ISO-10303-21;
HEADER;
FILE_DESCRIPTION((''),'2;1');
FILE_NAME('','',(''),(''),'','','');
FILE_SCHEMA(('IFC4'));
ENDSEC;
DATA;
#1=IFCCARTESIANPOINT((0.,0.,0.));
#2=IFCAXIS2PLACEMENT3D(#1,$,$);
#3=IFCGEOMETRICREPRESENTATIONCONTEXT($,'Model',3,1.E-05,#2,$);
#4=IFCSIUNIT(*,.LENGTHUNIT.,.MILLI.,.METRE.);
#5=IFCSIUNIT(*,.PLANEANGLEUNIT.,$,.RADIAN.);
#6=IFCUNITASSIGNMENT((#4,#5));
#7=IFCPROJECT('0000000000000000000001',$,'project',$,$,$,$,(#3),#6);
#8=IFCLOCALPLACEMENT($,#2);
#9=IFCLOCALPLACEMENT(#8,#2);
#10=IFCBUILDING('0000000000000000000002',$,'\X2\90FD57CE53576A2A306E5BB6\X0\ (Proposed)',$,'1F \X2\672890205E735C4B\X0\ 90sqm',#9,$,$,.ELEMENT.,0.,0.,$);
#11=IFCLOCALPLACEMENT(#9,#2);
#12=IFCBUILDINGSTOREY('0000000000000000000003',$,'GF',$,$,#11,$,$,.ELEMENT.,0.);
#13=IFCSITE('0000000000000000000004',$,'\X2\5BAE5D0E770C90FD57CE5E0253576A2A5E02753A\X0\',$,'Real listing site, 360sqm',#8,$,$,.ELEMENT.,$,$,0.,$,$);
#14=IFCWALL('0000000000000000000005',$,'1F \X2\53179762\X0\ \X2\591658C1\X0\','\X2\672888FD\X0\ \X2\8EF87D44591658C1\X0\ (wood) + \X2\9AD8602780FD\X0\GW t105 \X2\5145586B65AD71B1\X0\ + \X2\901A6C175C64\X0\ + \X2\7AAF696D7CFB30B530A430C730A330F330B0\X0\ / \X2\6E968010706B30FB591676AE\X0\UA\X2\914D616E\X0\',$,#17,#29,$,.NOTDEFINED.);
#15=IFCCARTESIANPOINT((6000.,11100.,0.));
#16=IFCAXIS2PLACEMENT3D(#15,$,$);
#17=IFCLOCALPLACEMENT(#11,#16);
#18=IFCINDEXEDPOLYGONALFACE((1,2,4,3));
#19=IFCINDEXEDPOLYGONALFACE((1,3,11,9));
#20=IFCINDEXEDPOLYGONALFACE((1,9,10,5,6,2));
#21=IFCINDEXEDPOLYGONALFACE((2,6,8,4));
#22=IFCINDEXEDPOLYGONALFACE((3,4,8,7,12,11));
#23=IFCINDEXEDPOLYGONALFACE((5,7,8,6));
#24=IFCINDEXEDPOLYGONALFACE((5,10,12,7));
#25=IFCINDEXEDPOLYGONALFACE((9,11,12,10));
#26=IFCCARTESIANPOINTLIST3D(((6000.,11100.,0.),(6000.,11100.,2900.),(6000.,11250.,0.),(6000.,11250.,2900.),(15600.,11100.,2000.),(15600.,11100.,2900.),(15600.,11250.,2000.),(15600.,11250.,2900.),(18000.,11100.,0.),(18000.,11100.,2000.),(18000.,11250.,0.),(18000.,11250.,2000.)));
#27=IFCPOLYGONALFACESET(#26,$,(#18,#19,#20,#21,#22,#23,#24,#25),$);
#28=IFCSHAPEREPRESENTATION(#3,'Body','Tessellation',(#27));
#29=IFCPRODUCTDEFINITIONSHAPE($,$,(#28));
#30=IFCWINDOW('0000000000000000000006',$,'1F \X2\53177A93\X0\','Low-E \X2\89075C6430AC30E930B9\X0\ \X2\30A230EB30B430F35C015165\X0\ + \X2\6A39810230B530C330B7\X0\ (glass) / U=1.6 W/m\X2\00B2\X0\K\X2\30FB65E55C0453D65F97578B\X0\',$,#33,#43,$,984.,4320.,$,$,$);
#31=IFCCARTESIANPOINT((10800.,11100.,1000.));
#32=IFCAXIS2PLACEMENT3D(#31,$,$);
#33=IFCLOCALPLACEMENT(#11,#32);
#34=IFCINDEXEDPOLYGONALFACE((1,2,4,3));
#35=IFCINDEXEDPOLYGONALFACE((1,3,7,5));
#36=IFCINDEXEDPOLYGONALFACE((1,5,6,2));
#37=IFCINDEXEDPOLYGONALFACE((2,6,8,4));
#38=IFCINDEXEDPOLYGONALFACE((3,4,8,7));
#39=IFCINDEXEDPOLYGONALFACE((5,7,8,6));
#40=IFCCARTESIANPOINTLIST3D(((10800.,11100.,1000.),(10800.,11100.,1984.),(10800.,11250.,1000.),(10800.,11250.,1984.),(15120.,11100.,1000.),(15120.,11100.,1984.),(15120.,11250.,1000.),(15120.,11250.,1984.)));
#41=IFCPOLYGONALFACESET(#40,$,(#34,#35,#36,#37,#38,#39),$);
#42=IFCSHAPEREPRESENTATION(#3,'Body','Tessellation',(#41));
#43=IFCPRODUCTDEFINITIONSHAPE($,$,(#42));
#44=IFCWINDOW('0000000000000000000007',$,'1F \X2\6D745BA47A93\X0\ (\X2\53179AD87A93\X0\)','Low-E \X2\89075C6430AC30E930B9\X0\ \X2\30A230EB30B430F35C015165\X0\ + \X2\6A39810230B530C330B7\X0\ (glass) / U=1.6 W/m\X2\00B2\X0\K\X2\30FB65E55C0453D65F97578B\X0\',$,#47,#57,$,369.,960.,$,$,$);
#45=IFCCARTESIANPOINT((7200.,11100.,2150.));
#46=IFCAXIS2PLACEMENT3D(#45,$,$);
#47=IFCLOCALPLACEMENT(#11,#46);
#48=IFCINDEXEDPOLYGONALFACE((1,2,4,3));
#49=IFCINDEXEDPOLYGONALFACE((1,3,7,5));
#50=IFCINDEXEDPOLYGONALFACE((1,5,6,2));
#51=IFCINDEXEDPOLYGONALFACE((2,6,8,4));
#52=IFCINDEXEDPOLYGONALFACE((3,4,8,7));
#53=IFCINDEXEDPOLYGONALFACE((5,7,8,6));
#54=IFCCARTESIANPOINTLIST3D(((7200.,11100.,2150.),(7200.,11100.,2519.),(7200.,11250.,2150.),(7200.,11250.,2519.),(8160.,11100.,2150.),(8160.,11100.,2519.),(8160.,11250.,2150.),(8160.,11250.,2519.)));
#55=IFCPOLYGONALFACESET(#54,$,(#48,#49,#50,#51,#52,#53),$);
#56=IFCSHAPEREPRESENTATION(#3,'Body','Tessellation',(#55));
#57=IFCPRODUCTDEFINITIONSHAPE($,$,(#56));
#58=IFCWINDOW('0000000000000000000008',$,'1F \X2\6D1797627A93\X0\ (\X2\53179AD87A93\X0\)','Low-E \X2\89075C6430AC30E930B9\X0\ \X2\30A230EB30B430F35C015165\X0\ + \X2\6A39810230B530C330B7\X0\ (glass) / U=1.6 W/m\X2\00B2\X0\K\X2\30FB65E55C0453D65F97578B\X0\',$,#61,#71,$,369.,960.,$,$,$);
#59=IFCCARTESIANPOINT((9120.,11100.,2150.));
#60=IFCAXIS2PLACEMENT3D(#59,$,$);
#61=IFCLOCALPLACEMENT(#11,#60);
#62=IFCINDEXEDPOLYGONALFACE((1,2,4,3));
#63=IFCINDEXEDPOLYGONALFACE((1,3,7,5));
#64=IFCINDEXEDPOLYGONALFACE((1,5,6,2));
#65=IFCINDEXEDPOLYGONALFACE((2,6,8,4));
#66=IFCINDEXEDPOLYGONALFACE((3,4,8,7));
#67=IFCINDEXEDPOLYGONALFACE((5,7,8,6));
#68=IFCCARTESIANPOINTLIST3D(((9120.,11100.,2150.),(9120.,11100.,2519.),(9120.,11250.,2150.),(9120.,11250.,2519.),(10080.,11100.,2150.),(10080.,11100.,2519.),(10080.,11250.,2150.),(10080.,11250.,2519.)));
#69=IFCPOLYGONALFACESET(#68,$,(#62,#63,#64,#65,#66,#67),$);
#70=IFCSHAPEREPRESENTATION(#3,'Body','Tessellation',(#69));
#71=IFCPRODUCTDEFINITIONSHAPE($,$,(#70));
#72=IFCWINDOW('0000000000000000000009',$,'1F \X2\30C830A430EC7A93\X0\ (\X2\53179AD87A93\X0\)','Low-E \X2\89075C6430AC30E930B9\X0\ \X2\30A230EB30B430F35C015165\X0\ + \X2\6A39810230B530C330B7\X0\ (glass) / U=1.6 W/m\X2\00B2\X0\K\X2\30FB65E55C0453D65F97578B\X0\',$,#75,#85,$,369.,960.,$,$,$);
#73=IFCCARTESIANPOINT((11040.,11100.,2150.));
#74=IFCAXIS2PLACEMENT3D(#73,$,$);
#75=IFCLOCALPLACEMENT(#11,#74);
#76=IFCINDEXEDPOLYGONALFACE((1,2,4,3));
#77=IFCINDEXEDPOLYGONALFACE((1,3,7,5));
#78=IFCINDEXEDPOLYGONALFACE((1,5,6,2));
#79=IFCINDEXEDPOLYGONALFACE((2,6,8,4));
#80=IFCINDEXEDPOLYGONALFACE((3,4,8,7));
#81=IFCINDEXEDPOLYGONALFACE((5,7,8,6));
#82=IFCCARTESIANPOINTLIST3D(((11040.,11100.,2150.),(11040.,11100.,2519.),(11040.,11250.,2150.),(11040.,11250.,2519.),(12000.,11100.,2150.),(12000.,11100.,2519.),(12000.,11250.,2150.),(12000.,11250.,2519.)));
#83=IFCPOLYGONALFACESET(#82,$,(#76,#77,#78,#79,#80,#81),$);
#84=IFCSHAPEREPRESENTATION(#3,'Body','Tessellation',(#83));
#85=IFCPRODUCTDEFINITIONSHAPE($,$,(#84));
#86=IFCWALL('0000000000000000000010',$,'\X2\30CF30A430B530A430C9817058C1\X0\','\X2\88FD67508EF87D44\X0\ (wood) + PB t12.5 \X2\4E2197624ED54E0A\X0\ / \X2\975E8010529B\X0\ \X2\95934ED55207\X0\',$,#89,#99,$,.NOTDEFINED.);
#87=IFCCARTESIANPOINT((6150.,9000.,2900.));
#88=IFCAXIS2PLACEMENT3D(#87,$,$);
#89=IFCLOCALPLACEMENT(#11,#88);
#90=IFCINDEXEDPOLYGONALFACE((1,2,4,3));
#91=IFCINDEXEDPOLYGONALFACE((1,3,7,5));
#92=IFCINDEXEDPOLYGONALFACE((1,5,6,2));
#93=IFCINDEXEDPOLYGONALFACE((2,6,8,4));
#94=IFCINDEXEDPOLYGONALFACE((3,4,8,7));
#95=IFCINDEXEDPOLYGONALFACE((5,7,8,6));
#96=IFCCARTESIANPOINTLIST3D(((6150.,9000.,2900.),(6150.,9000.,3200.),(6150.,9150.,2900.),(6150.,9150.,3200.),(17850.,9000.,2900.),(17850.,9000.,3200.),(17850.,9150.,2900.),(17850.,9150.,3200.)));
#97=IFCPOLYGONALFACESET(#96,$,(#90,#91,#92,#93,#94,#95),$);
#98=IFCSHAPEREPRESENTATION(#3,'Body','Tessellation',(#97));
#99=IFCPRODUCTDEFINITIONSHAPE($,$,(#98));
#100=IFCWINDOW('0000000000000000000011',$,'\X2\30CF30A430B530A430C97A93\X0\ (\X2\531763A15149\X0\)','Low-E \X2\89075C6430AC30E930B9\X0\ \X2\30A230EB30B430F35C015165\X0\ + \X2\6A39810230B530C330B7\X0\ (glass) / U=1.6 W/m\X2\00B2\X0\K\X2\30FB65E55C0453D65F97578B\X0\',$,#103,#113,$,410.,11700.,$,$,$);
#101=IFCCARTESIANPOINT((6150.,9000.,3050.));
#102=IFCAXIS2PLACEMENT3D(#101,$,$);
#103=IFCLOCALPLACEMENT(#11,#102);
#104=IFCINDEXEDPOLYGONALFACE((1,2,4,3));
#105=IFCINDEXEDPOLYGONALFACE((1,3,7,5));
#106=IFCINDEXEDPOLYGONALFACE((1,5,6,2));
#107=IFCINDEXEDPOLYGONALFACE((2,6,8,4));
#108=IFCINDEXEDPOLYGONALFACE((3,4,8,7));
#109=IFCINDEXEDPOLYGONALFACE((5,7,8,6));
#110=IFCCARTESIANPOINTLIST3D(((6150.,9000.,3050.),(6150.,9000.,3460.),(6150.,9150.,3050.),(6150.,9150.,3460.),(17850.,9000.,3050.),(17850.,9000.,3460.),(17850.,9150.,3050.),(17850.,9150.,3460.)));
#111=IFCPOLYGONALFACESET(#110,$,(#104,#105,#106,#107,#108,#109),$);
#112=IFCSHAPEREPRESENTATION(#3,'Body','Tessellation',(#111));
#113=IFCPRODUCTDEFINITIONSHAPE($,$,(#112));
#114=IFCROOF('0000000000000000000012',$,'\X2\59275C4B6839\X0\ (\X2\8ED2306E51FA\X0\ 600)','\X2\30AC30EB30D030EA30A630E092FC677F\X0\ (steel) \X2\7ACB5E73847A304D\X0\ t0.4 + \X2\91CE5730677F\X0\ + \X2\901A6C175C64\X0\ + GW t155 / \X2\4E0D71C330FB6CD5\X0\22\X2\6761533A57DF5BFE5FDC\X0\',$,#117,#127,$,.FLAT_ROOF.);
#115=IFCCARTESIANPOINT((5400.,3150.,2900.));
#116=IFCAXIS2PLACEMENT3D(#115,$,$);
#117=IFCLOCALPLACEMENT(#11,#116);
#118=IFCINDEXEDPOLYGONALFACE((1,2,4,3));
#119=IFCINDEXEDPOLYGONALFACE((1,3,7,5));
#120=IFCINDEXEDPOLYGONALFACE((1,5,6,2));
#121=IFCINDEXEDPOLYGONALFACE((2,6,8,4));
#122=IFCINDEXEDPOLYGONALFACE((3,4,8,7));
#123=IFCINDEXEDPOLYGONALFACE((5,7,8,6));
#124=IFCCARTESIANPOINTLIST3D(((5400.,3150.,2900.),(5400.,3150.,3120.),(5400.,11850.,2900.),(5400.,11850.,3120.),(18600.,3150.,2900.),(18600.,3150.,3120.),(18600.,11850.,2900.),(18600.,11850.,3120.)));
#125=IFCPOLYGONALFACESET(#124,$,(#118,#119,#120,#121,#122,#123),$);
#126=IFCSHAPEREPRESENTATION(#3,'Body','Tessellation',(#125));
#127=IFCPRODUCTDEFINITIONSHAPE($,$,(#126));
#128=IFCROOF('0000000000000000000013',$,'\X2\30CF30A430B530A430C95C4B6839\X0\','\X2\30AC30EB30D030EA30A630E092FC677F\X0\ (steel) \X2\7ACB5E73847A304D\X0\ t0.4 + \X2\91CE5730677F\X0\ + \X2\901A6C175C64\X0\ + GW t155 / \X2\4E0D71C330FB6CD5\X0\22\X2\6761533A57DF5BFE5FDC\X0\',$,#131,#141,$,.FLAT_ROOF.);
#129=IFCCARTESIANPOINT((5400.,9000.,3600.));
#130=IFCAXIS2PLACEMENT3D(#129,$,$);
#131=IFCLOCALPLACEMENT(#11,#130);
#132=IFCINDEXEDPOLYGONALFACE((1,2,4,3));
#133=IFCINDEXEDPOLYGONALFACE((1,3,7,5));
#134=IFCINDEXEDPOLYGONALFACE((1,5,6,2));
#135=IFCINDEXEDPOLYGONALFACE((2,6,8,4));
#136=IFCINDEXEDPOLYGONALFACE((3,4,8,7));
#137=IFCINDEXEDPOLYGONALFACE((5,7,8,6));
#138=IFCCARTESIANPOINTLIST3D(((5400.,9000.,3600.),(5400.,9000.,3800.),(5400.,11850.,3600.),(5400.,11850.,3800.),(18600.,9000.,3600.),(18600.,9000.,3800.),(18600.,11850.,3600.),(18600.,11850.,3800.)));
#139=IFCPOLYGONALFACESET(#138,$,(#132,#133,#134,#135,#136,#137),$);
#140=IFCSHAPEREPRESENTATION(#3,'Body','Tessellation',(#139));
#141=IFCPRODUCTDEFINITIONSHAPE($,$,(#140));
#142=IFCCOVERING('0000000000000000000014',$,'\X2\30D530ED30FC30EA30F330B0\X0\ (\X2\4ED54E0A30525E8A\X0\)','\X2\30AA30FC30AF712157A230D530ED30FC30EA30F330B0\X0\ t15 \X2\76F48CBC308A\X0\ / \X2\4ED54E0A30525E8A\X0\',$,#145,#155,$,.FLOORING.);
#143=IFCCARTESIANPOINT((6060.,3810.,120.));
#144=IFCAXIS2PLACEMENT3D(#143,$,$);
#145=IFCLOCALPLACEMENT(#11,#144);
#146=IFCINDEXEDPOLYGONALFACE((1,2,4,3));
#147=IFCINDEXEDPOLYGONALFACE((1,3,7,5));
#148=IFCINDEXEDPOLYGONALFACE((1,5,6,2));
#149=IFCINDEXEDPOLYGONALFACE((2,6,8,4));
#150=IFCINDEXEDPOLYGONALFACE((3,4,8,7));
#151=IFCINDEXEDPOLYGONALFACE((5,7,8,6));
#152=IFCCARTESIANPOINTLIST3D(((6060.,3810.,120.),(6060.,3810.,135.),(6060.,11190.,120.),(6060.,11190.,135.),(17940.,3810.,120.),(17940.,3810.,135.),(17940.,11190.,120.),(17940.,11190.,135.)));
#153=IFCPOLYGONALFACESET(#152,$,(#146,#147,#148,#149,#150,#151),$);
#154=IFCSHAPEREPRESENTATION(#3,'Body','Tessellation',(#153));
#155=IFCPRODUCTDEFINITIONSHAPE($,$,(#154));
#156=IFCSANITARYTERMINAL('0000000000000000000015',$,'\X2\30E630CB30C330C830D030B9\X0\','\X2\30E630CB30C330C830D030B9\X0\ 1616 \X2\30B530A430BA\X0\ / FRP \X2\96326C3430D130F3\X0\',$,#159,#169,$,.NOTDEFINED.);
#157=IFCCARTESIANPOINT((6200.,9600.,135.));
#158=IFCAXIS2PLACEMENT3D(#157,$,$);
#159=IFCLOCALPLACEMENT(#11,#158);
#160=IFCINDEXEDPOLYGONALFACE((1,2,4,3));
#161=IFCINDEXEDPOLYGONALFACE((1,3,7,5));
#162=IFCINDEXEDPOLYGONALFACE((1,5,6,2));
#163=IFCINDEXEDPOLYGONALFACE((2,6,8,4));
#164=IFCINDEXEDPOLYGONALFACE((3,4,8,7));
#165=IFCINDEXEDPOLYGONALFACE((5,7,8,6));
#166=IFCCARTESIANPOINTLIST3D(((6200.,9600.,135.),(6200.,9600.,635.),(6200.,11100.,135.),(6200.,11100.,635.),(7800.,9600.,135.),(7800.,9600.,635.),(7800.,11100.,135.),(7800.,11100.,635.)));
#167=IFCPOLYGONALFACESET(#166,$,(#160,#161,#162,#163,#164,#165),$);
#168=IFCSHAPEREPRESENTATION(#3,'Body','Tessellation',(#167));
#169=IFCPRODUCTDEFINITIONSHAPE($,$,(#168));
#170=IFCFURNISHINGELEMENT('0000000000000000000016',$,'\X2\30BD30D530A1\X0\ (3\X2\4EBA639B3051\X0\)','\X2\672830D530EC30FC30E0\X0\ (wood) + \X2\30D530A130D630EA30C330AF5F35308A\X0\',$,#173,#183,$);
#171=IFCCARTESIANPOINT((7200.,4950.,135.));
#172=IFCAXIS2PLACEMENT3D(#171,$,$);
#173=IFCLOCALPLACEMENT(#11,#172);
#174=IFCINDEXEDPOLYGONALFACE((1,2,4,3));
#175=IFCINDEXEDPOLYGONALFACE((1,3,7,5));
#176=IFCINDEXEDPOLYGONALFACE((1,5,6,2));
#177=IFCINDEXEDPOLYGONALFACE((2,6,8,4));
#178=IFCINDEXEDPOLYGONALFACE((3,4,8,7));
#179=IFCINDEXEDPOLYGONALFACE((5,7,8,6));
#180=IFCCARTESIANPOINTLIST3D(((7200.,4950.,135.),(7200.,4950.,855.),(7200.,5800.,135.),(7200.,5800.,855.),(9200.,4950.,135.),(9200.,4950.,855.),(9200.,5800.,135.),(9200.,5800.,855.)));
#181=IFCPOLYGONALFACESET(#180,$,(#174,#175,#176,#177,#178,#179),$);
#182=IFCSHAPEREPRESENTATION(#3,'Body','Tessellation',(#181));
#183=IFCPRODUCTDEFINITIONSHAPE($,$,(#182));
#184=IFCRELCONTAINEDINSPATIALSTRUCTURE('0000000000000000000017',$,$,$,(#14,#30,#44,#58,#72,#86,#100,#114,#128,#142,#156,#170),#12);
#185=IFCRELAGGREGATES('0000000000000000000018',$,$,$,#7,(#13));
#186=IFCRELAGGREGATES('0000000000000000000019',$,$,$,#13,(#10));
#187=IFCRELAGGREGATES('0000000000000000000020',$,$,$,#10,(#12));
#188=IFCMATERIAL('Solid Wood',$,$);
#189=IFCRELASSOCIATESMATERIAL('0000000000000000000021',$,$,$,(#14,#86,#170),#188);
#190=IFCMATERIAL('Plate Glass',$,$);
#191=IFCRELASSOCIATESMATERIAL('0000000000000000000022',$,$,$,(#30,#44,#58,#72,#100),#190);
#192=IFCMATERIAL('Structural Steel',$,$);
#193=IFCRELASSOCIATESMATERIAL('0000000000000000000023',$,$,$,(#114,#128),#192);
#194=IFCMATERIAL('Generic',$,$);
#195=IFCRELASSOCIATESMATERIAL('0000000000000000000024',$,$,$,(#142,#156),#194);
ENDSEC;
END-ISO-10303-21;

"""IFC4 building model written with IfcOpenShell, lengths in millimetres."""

from ifc_helpers import new_model, si_unit, frame, frame_2d, origin, place, context, project, spatial, rectangle, extrude, material, element, fill, save


model = new_model("IFC4")

# Units and contexts
model_context = context("Model", 3, precision=1e-05, world=origin())
ifc_project = project(units=[si_unit("LENGTHUNIT", "METRE", prefix="MILLI"), si_unit("PLANEANGLEUNIT", "RADIAN")], contexts=[model_context])

# Site, building, storey
site_placement = place(None, origin())
site = spatial("IfcSite", under=ifc_project, at=site_placement, Name="宮崎県都城市南横市町", ObjectType="Real listing site, 360sqm", CompositionType="ELEMENT", RefElevation=0.0)
building_placement = place(site_placement, origin())
building = spatial("IfcBuilding", under=site, at=building_placement, Name="都城南横の家 (Proposed)", ObjectType="1F 木造平屋 90sqm", CompositionType="ELEMENT", ElevationOfRefHeight=0.0, ElevationOfTerrain=0.0)
storey_placement = place(building_placement, origin())
storey = spatial("IfcBuildingStorey", under=building, at=storey_placement, Name="GF", CompositionType="ELEMENT", Elevation=0.0)

# Shared definitions
ifc_material_1 = material(Name="Solid Wood")

# Shared definitions
ifc_material_2 = material(Name="Plate Glass")

# Wall, openings, windows
wall_1_placement = place(storey_placement, frame((6000.0, 11100.0, 0.0)))
wall_1 = element("IfcWall", 1, at=wall_1_placement, inside=storey, material=ifc_material_1, Name="1F 北面 外壁", Description="木製 軸組外壁 (wood) + 高性能GW t105 充填断熱 + 通気層 + 窯業系サイディング / 準耐火・外皮UA配慮", PredefinedType="NOTDEFINED", context=model_context, shape_type="SweptSolid", body=[
    extrude(rectangle(XDim=12000.0, YDim=150.0, at=frame_2d((6000.0, 75.0))), frame((6000.0, 11100.0, 0.0)), (0.0, 0.0, 1.0), 2900.0),
])
opening_1_placement = place(storey_placement, frame((10800.0, 11100.0, 1000.0)))
opening_1 = element("IfcOpeningElement", 2, at=opening_1_placement, cuts=wall_1, PredefinedType="NOTDEFINED", context=model_context, shape_type="SweptSolid", body=[
    extrude(rectangle(XDim=4320.0, YDim=150.0, at=frame_2d((2160.0, 75.0))), frame((10800.0, 11100.0, 1000.0)), (0.0, 0.0, 1.0), 984.0),
])
opening_2_placement = place(storey_placement, frame((7200.0, 11100.0, 2150.0)))
opening_2 = element("IfcOpeningElement", 3, at=opening_2_placement, cuts=wall_1, PredefinedType="NOTDEFINED", context=model_context, shape_type="SweptSolid", body=[
    extrude(rectangle(XDim=960.0, YDim=150.0, at=frame_2d((480.0, 75.0))), frame((7200.0, 11100.0, 2150.0)), (0.0, 0.0, 1.0), 369.0),
])
opening_3_placement = place(storey_placement, frame((9120.0, 11100.0, 2150.0)))
opening_3 = element("IfcOpeningElement", 4, at=opening_3_placement, cuts=wall_1, PredefinedType="NOTDEFINED", context=model_context, shape_type="SweptSolid", body=[
    extrude(rectangle(XDim=960.0, YDim=150.0, at=frame_2d((480.0, 75.0))), frame((9120.0, 11100.0, 2150.0)), (0.0, 0.0, 1.0), 369.0),
])
opening_4_placement = place(storey_placement, frame((11040.0, 11100.0, 2150.0)))
opening_4 = element("IfcOpeningElement", 5, at=opening_4_placement, cuts=wall_1, PredefinedType="NOTDEFINED", context=model_context, shape_type="SweptSolid", body=[
    extrude(rectangle(XDim=960.0, YDim=150.0, at=frame_2d((480.0, 75.0))), frame((11040.0, 11100.0, 2150.0)), (0.0, 0.0, 1.0), 369.0),
])
window_1_placement = place(storey_placement, frame((10800.0, 11100.0, 1000.0)))
window_1 = element("IfcWindow", 6, at=window_1_placement, inside=storey, material=ifc_material_2, Name="1F 北窓", Description="Low-E 複層ガラス アルゴン封入 + 樹脂サッシ (glass) / U=1.6 W/m²K・日射取得型", OverallHeight=984.0, OverallWidth=4320.0, context=model_context, shape_type="SweptSolid", body=[
    extrude(rectangle(XDim=4320.0, YDim=150.0, at=frame_2d((2160.0, 75.0))), frame((10800.0, 11100.0, 1000.0)), (0.0, 0.0, 1.0), 984.0),
])
fill(opening_1, window_1)
window_2_placement = place(storey_placement, frame((7200.0, 11100.0, 2150.0)))
window_2 = element("IfcWindow", 7, at=window_2_placement, inside=storey, material=ifc_material_2, Name="1F 浴室窓 (北高窓)", Description="Low-E 複層ガラス アルゴン封入 + 樹脂サッシ (glass) / U=1.6 W/m²K・日射取得型", OverallHeight=369.0, OverallWidth=960.0, context=model_context, shape_type="SweptSolid", body=[
    extrude(rectangle(XDim=960.0, YDim=150.0, at=frame_2d((480.0, 75.0))), frame((7200.0, 11100.0, 2150.0)), (0.0, 0.0, 1.0), 369.0),
])
fill(opening_2, window_2)
window_3_placement = place(storey_placement, frame((9120.0, 11100.0, 2150.0)))
window_3 = element("IfcWindow", 8, at=window_3_placement, inside=storey, material=ifc_material_2, Name="1F 洗面窓 (北高窓)", Description="Low-E 複層ガラス アルゴン封入 + 樹脂サッシ (glass) / U=1.6 W/m²K・日射取得型", OverallHeight=369.0, OverallWidth=960.0, context=model_context, shape_type="SweptSolid", body=[
    extrude(rectangle(XDim=960.0, YDim=150.0, at=frame_2d((480.0, 75.0))), frame((9120.0, 11100.0, 2150.0)), (0.0, 0.0, 1.0), 369.0),
])
fill(opening_3, window_3)
window_4_placement = place(storey_placement, frame((11040.0, 11100.0, 2150.0)))
window_4 = element("IfcWindow", 9, at=window_4_placement, inside=storey, material=ifc_material_2, Name="1F トイレ窓 (北高窓)", Description="Low-E 複層ガラス アルゴン封入 + 樹脂サッシ (glass) / U=1.6 W/m²K・日射取得型", OverallHeight=369.0, OverallWidth=960.0, context=model_context, shape_type="SweptSolid", body=[
    extrude(rectangle(XDim=960.0, YDim=150.0, at=frame_2d((480.0, 75.0))), frame((11040.0, 11100.0, 2150.0)), (0.0, 0.0, 1.0), 369.0),
])
fill(opening_4, window_4)

# Wall, opening, window
wall_2_placement = place(storey_placement, frame((6150.0, 9000.0, 2900.0)))
wall_2 = element("IfcWall", 10, at=wall_2_placement, inside=storey, material=ifc_material_1, Name="ハイサイド腰壁", Description="製材軸組 (wood) + PB t12.5 両面仕上 / 非耐力 間仕切", PredefinedType="NOTDEFINED", context=model_context, shape_type="SweptSolid", body=[
    extrude(rectangle(XDim=11700.0, YDim=150.0, at=frame_2d((5850.0, 75.0))), frame((6150.0, 9000.0, 2900.0)), (0.0, 0.0, 1.0), 700.0),
])
opening_5_placement = place(storey_placement, frame((6150.0, 9000.0, 3050.0)))
opening_5 = element("IfcOpeningElement", 11, at=opening_5_placement, cuts=wall_2, PredefinedType="NOTDEFINED", context=model_context, shape_type="SweptSolid", body=[
    extrude(rectangle(XDim=11700.0, YDim=150.0, at=frame_2d((5850.0, 75.0))), frame((6150.0, 9000.0, 3050.0)), (0.0, 0.0, 1.0), 410.0),
])
window_5_placement = place(storey_placement, frame((6150.0, 9000.0, 3050.0)))
window_5 = element("IfcWindow", 12, at=window_5_placement, inside=storey, material=ifc_material_2, Name="ハイサイド窓 (北採光)", Description="Low-E 複層ガラス アルゴン封入 + 樹脂サッシ (glass) / U=1.6 W/m²K・日射取得型", OverallHeight=410.0, OverallWidth=11700.0, context=model_context, shape_type="SweptSolid", body=[
    extrude(rectangle(XDim=11700.0, YDim=150.0, at=frame_2d((5850.0, 75.0))), frame((6150.0, 9000.0, 3050.0)), (0.0, 0.0, 1.0), 410.0),
])
fill(opening_5, window_5)

# Roofs
ifc_material_3 = material(Name="Structural Steel")
roof_1_placement = place(storey_placement, frame((5400.0, 3150.0, 2900.0)))
element("IfcRoof", 13, at=roof_1_placement, inside=storey, material=ifc_material_3, Name="大屋根 (軒の出 600)", Description="ガルバリウム鋼板 (steel) 立平葺き t0.4 + 野地板 + 通気層 + GW t155 / 不燃・法22条区域対応", PredefinedType="FLAT_ROOF", context=model_context, shape_type="SweptSolid", body=[
    extrude(rectangle(XDim=13200.0, YDim=8700.0, at=frame_2d((6600.0, 4350.0))), frame((5400.0, 3150.0, 2900.0)), (0.0, 0.0, 1.0), 220.0),
])
roof_2_placement = place(storey_placement, frame((5400.0, 9000.0, 3600.0)))
element("IfcRoof", 14, at=roof_2_placement, inside=storey, material=ifc_material_3, Name="ハイサイド屋根", Description="ガルバリウム鋼板 (steel) 立平葺き t0.4 + 野地板 + 通気層 + GW t155 / 不燃・法22条区域対応", PredefinedType="FLAT_ROOF", context=model_context, shape_type="SweptSolid", body=[
    extrude(rectangle(XDim=13200.0, YDim=2850.0, at=frame_2d((6600.0, 1425.0))), frame((5400.0, 9000.0, 3600.0)), (0.0, 0.0, 1.0), 200.0),
])

# Covering
ifc_material_4 = material(Name="Generic")
covering_placement = place(storey_placement, frame((6060.0, 3810.0, 120.0)))
element("IfcCovering", 15, at=covering_placement, inside=storey, material=ifc_material_4, Name="フローリング (仕上げ床)", Description="オーク無垢フローリング t15 直貼り / 仕上げ床", PredefinedType="FLOORING", context=model_context, shape_type="SweptSolid", body=[
    extrude(rectangle(XDim=11880.0, YDim=7380.0, at=frame_2d((5940.0, 3690.0))), frame((6060.0, 3810.0, 120.0)), (0.0, 0.0, 1.0), 15.0),
])

# Sanitary terminal
sanitary_terminal_placement = place(storey_placement, frame((6200.0, 9600.0, 135.0)))
element("IfcSanitaryTerminal", 16, at=sanitary_terminal_placement, inside=storey, material=ifc_material_4, Name="ユニットバス", Description="ユニットバス 1616 サイズ / FRP 防水パン", PredefinedType="NOTDEFINED", context=model_context, shape_type="SweptSolid", body=[
    extrude(rectangle(XDim=1600.0, YDim=1500.0, at=frame_2d((800.0, 750.0))), frame((6200.0, 9600.0, 135.0)), (0.0, 0.0, 1.0), 500.0),
])

# Furnishing element
furnishing_1_placement = place(storey_placement, frame((7200.0, 4950.0, 135.0)))
element("IfcFurnishingElement", 17, at=furnishing_1_placement, inside=storey, material=ifc_material_1, Name="ソファ (3人掛け)", Description="木フレーム (wood) + ファブリック張り", context=model_context, shape_type="SweptSolid", body=[
    extrude(rectangle(XDim=2000.0, YDim=850.0, at=frame_2d((1000.0, 425.0))), frame((7200.0, 4950.0, 135.0)), (0.0, 0.0, 1.0), 720.0),
])

save(model, "model.ifc")
